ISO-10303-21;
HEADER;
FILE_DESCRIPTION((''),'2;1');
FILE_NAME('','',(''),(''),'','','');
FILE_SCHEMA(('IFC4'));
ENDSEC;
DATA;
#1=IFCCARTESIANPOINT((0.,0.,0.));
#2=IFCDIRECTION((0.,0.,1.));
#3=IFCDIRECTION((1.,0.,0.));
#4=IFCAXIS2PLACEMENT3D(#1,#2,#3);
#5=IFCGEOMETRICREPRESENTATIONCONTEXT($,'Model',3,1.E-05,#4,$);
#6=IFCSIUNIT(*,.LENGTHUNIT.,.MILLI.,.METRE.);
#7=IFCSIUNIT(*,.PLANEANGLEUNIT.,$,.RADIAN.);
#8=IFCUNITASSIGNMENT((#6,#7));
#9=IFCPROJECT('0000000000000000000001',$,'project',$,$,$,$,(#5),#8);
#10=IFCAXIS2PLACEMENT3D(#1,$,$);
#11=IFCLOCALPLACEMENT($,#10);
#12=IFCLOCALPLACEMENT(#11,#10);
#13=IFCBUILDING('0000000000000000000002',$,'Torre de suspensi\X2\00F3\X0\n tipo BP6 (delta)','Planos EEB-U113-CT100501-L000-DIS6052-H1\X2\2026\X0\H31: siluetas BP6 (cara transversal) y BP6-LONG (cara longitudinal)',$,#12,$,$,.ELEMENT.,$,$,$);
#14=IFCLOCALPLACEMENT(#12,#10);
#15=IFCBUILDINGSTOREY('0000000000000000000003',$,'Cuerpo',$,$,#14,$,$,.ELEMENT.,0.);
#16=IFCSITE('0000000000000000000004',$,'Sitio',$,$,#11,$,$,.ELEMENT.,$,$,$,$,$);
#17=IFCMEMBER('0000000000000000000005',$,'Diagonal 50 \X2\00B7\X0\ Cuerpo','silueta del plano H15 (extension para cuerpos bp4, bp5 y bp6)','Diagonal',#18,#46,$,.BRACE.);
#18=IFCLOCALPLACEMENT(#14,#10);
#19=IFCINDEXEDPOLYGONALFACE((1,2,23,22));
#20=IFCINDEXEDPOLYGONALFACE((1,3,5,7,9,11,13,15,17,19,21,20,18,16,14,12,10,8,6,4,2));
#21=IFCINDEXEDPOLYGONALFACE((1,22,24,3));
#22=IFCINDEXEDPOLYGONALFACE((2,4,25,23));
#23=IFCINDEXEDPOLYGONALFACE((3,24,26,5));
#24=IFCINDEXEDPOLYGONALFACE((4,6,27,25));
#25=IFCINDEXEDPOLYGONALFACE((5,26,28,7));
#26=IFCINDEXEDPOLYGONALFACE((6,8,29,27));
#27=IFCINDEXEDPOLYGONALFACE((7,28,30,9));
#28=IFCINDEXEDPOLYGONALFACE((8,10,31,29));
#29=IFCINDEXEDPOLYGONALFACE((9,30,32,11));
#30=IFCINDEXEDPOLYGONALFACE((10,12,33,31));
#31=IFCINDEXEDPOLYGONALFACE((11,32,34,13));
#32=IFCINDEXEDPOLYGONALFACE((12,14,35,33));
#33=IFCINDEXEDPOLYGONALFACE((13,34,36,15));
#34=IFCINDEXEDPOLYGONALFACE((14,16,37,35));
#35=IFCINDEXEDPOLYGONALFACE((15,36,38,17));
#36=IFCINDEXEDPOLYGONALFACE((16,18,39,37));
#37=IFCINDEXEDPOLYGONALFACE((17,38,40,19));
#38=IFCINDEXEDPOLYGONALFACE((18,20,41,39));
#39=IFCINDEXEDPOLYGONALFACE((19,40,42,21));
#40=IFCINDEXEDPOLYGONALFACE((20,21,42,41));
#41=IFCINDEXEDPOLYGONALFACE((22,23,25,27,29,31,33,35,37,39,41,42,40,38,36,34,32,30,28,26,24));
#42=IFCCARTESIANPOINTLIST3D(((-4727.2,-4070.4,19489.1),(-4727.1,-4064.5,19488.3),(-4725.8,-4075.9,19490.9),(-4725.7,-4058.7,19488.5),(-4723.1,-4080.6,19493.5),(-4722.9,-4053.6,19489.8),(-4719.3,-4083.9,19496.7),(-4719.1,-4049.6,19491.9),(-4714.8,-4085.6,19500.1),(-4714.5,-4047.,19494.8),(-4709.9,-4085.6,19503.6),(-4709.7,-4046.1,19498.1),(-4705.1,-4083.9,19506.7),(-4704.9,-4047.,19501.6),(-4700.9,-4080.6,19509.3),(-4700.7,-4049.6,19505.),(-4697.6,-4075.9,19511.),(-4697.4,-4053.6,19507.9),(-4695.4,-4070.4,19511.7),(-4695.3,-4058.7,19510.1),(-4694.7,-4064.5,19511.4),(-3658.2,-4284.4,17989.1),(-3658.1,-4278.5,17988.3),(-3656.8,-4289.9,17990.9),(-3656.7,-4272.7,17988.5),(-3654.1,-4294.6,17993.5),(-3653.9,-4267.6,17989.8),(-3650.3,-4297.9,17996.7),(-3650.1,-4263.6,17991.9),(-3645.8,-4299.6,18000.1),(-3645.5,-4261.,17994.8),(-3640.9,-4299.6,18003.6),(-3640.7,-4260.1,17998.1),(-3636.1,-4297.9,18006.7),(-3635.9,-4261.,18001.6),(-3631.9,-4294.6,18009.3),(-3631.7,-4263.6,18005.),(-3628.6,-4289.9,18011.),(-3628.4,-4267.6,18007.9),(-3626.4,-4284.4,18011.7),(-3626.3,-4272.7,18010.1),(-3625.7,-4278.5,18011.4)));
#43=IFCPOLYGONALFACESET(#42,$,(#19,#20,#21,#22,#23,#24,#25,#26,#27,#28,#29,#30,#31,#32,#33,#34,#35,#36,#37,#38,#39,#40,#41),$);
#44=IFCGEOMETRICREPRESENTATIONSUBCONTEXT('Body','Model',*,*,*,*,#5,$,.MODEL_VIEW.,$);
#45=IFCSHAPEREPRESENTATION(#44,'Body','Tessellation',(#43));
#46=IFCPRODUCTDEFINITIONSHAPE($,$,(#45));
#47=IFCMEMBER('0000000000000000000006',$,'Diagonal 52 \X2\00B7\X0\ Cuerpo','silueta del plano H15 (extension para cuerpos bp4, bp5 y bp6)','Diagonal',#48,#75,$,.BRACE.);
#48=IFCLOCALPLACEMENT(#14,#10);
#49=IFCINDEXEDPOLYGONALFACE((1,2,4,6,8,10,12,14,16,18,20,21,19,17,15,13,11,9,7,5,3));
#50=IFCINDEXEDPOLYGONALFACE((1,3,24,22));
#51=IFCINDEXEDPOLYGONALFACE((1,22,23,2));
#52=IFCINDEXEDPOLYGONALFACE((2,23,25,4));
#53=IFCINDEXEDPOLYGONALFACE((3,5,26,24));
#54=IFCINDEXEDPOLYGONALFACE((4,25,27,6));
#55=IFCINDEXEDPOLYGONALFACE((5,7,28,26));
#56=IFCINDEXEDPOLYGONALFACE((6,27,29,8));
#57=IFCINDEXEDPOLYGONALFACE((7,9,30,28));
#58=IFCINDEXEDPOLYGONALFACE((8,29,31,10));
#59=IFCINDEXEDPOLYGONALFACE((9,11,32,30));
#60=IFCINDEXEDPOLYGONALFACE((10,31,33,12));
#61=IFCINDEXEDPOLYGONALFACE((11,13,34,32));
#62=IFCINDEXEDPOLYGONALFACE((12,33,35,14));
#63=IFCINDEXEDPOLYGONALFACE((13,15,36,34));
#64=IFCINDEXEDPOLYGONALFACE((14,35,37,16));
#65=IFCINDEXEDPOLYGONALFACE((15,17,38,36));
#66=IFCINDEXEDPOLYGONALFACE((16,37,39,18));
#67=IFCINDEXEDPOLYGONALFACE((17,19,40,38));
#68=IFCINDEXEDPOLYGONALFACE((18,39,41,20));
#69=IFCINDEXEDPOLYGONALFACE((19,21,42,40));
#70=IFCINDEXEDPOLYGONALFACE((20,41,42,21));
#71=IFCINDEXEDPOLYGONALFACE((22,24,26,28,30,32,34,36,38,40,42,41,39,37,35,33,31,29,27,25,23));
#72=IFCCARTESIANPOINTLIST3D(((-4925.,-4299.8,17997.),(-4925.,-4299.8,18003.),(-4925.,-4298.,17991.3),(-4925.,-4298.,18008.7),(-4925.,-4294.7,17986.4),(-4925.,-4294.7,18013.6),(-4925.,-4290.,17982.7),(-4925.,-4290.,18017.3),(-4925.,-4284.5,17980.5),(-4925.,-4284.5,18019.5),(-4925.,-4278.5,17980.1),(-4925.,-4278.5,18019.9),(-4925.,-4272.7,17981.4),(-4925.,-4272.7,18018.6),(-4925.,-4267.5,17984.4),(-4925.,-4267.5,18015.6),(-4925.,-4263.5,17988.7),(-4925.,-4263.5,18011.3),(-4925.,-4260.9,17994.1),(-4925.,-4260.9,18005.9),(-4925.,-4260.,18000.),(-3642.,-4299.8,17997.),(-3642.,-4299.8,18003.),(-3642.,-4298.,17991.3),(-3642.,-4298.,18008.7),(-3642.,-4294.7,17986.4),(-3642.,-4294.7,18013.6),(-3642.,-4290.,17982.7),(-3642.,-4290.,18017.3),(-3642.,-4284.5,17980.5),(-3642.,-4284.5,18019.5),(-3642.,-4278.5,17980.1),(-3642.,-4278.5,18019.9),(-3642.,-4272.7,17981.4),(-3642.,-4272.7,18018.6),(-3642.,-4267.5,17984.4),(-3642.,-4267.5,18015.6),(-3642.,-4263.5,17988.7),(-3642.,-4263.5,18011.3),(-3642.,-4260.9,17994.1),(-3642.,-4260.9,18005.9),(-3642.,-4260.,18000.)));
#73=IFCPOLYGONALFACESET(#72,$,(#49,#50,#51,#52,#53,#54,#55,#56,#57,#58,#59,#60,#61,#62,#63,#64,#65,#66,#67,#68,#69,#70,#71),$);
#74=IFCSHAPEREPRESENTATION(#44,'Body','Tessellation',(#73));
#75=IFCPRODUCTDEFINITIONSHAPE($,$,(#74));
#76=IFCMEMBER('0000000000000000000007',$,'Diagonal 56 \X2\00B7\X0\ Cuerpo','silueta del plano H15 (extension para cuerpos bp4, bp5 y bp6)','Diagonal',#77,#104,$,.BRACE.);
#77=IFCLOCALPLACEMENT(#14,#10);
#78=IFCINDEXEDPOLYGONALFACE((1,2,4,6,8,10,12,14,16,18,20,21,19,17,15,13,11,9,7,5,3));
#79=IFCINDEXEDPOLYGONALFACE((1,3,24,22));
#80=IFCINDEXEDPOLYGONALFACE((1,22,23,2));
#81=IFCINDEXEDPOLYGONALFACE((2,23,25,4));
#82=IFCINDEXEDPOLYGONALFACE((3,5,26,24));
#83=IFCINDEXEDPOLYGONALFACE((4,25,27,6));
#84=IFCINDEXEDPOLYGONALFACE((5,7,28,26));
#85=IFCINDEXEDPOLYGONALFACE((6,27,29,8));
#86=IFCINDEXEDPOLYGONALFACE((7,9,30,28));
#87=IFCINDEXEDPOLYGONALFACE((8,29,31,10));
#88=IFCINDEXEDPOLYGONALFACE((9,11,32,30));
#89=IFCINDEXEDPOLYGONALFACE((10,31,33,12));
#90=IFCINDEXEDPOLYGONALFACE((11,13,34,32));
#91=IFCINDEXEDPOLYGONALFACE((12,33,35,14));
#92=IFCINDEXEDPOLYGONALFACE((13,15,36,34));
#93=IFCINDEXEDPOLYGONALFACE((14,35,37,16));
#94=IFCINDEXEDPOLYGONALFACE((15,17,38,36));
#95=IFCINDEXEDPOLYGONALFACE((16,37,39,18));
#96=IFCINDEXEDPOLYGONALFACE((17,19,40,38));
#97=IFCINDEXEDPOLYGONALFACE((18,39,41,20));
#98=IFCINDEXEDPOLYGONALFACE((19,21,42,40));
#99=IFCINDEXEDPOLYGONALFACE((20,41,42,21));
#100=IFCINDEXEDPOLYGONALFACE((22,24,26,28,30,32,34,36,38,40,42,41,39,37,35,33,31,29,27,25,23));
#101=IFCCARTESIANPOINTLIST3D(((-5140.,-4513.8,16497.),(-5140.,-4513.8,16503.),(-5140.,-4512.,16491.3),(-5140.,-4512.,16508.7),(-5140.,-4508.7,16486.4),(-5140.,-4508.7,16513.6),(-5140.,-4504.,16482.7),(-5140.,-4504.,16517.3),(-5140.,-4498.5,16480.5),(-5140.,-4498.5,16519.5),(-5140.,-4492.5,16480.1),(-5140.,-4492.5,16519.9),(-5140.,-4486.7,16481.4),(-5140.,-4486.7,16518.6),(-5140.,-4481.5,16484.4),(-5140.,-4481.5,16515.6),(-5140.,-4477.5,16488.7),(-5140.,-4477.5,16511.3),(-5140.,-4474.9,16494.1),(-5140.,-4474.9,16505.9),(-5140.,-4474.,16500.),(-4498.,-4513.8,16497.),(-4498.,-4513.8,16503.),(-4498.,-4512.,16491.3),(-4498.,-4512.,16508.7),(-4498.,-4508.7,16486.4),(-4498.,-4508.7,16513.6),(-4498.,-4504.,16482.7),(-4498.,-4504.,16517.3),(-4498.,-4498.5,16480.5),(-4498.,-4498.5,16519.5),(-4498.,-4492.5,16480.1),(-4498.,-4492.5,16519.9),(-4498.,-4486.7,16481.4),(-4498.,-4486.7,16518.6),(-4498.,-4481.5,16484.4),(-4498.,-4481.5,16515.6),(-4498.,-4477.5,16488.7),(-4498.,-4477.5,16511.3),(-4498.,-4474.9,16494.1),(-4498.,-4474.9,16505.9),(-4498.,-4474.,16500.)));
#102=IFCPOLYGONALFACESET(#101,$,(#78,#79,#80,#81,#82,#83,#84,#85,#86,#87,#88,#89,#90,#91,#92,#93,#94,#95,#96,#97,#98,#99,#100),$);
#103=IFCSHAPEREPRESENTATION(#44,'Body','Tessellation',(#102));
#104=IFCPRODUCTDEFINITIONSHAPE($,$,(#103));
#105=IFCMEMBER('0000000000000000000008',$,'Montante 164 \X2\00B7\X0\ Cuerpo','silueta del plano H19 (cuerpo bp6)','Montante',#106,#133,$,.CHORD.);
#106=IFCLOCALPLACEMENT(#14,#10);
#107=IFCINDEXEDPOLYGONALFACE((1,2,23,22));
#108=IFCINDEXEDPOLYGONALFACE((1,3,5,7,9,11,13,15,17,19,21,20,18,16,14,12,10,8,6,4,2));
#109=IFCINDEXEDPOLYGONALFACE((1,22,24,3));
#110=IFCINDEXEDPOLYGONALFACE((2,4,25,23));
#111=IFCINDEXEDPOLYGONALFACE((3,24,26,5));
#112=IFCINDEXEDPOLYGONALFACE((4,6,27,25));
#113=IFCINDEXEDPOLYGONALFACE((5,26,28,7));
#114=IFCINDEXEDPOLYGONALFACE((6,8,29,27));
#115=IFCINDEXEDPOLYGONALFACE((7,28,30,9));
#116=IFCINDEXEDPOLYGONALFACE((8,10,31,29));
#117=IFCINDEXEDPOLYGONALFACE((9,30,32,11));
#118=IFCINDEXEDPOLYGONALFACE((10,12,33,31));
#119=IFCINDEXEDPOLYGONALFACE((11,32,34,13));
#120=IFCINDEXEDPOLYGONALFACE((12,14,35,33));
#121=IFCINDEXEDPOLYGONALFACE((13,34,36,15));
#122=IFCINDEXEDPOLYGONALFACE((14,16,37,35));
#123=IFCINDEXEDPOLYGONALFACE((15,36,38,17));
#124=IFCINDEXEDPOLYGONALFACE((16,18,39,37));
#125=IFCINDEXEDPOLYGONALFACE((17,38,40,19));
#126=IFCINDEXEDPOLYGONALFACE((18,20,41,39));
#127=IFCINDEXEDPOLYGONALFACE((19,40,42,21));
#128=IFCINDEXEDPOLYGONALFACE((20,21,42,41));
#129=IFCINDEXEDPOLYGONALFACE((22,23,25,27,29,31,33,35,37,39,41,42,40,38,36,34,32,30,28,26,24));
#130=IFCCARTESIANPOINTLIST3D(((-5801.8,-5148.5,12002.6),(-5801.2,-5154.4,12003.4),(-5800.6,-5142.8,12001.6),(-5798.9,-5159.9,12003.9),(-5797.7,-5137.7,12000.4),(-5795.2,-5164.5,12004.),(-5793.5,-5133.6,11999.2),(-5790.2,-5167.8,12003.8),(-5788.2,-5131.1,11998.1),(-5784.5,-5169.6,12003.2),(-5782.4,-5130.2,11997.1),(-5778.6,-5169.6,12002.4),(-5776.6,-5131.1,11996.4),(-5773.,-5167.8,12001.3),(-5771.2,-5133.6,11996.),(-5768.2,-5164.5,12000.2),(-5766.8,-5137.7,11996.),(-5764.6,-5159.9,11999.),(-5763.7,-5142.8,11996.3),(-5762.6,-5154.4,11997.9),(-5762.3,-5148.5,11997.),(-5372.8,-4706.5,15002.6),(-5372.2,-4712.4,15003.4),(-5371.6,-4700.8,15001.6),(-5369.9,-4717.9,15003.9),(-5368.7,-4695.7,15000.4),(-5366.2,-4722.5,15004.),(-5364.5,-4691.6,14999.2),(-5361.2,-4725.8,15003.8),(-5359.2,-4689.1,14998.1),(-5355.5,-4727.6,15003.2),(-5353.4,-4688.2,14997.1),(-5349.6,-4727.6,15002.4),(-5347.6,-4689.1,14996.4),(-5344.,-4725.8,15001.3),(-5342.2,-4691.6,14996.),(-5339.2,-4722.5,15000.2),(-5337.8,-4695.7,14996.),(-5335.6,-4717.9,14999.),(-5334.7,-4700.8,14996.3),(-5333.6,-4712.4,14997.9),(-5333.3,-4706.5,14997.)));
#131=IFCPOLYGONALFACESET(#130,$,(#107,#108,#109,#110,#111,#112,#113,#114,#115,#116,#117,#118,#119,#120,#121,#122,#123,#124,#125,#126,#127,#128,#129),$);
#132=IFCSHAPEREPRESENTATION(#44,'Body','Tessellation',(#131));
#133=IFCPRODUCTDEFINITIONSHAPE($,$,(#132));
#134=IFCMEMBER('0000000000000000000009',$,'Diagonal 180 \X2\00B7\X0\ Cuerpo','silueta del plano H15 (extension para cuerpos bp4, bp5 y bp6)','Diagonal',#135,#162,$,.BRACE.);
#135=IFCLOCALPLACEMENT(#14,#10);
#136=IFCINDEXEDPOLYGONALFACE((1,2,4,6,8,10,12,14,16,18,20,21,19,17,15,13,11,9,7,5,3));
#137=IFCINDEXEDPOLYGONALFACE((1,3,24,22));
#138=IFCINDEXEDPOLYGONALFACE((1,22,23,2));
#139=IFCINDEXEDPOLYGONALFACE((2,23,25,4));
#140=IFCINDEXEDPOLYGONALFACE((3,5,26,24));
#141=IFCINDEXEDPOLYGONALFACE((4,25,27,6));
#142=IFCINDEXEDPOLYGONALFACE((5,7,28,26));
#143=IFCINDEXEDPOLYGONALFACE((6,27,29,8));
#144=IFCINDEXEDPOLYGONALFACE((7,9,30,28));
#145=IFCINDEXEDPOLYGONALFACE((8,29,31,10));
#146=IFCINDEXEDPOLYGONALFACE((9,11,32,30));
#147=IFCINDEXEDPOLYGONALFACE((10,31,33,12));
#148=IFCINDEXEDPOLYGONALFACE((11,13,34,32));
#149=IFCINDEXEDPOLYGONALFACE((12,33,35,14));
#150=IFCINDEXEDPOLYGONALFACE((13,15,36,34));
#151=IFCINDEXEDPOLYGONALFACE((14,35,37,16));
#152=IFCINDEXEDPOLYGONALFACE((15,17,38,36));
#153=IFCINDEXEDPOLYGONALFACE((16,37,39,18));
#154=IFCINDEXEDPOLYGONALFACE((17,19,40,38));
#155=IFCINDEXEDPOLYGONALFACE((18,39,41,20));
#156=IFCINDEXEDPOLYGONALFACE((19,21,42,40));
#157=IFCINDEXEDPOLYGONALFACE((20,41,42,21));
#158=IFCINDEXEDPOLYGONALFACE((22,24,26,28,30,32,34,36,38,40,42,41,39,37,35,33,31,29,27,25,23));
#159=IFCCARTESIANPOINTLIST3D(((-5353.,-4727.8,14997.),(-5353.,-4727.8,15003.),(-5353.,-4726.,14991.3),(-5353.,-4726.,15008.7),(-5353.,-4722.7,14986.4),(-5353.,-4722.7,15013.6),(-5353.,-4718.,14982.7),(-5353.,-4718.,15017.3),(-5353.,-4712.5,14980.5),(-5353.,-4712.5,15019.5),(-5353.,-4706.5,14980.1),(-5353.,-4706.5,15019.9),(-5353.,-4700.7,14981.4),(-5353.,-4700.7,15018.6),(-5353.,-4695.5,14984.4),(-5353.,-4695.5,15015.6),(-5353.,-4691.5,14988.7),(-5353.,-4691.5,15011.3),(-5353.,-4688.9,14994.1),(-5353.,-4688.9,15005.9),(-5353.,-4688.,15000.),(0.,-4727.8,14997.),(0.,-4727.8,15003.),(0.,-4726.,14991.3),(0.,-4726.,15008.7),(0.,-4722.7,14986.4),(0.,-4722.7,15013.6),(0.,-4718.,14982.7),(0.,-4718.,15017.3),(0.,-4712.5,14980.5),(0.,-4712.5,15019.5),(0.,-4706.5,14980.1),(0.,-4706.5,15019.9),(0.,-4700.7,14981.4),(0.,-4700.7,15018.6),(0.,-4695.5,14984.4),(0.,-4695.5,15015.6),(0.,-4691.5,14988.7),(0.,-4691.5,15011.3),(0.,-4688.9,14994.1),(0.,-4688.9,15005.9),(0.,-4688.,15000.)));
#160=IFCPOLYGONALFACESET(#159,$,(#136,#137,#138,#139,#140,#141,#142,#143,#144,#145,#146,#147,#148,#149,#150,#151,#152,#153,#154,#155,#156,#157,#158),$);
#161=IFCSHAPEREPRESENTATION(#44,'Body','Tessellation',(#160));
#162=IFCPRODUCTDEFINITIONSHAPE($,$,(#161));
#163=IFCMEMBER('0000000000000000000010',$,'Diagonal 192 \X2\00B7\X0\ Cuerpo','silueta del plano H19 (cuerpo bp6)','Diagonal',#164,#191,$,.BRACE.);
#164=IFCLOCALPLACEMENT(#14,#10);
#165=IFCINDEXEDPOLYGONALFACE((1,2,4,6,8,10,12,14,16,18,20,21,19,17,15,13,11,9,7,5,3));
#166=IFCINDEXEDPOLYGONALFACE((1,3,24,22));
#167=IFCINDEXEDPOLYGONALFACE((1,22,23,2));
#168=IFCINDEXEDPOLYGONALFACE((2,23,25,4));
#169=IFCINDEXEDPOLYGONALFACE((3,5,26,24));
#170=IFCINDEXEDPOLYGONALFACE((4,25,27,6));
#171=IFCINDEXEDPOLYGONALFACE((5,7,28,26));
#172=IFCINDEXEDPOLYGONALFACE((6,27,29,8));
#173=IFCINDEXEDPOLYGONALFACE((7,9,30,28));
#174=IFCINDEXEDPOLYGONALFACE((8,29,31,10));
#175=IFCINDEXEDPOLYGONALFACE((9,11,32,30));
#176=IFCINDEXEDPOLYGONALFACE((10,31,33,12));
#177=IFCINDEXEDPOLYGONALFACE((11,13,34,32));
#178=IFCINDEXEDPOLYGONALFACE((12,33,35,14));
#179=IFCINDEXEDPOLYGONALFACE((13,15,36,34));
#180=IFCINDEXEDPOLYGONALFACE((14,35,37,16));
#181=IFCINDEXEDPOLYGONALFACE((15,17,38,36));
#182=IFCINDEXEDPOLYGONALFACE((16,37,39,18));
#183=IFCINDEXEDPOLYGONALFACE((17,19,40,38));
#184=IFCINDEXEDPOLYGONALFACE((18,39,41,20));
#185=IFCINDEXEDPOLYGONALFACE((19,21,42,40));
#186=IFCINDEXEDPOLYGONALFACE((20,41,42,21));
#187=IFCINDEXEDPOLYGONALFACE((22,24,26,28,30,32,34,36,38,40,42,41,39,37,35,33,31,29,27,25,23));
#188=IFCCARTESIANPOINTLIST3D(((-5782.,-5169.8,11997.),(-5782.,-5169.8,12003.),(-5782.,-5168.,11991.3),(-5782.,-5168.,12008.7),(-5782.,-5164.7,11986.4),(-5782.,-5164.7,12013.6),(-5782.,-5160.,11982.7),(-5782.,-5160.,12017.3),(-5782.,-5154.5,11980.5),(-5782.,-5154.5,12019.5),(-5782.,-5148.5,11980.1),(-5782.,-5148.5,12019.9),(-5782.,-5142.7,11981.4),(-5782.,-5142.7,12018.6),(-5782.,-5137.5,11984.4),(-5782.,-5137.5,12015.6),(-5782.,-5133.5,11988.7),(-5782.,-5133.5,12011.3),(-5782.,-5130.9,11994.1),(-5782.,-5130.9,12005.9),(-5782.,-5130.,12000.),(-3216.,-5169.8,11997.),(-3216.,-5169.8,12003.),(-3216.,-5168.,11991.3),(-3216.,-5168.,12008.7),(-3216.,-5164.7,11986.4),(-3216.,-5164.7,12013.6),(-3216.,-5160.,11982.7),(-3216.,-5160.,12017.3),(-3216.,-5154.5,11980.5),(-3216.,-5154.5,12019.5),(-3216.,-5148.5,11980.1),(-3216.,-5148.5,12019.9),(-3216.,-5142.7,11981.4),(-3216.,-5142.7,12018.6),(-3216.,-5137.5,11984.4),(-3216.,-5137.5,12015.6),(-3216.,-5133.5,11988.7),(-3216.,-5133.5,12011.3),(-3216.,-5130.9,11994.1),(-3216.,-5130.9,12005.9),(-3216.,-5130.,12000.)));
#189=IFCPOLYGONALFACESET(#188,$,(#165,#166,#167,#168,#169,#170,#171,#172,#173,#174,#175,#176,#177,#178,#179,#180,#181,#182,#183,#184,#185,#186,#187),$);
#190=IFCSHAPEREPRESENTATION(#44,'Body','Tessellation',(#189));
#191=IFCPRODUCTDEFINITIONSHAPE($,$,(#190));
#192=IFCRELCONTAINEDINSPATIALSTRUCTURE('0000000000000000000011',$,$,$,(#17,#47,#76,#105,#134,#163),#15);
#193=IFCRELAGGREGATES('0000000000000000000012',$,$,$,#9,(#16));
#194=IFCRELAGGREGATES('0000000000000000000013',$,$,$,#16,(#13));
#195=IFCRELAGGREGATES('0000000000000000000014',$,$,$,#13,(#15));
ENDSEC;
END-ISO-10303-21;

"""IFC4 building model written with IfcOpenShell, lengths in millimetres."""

from ifc_helpers import new_model, si_unit, frame, origin, origin_with_axes, place, context, subcontext, project, spatial, circle, extrude, element, save


model = new_model("IFC4")

# Units and contexts
model_context = context("Model", 3, precision=1e-05, world=origin_with_axes())
body_context = subcontext(model_context, "Body", "Model", "MODEL_VIEW")
ifc_project = project(units=[si_unit("LENGTHUNIT", "METRE", prefix="MILLI"), si_unit("PLANEANGLEUNIT", "RADIAN")], contexts=[model_context])

# Site, building, storey
site_placement = place(None, origin())
site = spatial("IfcSite", under=ifc_project, at=site_placement, Name="Sitio", CompositionType="ELEMENT")
building_placement = place(site_placement, origin())
building = spatial("IfcBuilding", under=site, at=building_placement, Name="Torre de suspensión tipo BP6 (delta)", Description="Planos EEB-U113-CT100501-L000-DIS6052-H1…H31: siluetas BP6 (cara transversal) y BP6-LONG (cara longitudinal)", CompositionType="ELEMENT")
storey_placement = place(building_placement, origin())
storey = spatial("IfcBuildingStorey", under=building, at=storey_placement, Name="Cuerpo", CompositionType="ELEMENT", Elevation=0.0)

# Members
member_1_placement = place(storey_placement, frame((-3642.0, -4280.0, 18000.0), z_axis=(-0.576487, 0.115405, 0.808915), x_axis=(0.066977, 0.993318, -0.093981)))
element("IfcMember", 1, at=member_1_placement, inside=storey, Name="Diagonal 50 · Cuerpo", Description="silueta del plano H15 (extension para cuerpos bp4, bp5 y bp6)", ObjectType="Diagonal", PredefinedType="BRACE", context=body_context, shape_type="SweptSolid", body=[
    extrude(circle(Radius=20.0), None, (0.0, 0.0, 1.0), 1854.3),
])
member_2_placement = place(storey_placement, frame((-3642.0, -4280.0, 18000.0), z_axis=(-1.0, 0.0, 0.0), x_axis=(0.0, 1.0, 0.0)))
element("IfcMember", 2, at=member_2_placement, inside=storey, Name="Diagonal 52 · Cuerpo", Description="silueta del plano H15 (extension para cuerpos bp4, bp5 y bp6)", ObjectType="Diagonal", PredefinedType="BRACE", context=body_context, shape_type="SweptSolid", body=[
    extrude(circle(Radius=20.0), None, (0.0, 0.0, 1.0), 1283.0),
])
member_3_placement = place(storey_placement, frame((-4498.0, -4494.0, 16500.0), z_axis=(-1.0, 0.0, 0.0), x_axis=(0.0, 1.0, 0.0)))
element("IfcMember", 3, at=member_3_placement, inside=storey, Name="Diagonal 56 · Cuerpo", Description="silueta del plano H15 (extension para cuerpos bp4, bp5 y bp6)", ObjectType="Diagonal", PredefinedType="BRACE", context=body_context, shape_type="SweptSolid", body=[
    extrude(circle(Radius=20.0), None, (0.0, 0.0, 1.0), 642.0),
])
member_4_placement = place(storey_placement, frame((-5353.0, -4708.0, 15000.0), z_axis=(-0.140078, -0.144323, -0.979566), x_axis=(-0.02043, 0.989531, -0.142869)))
element("IfcMember", 4, at=member_4_placement, inside=storey, Name="Montante 164 · Cuerpo", Description="silueta del plano H19 (cuerpo bp6)", ObjectType="Montante", PredefinedType="CHORD", context=body_context, shape_type="SweptSolid", body=[
    extrude(circle(Radius=20.0), None, (0.0, 0.0, 1.0), 3062.6),
])
member_5_placement = place(storey_placement, frame((-5353.0, -4708.0, 15000.0), z_axis=(1.0, 0.0, 0.0), x_axis=(0.0, 1.0, 0.0)))
element("IfcMember", 5, at=member_5_placement, inside=storey, Name="Diagonal 180 · Cuerpo", Description="silueta del plano H15 (extension para cuerpos bp4, bp5 y bp6)", ObjectType="Diagonal", PredefinedType="BRACE", context=body_context, shape_type="SweptSolid", body=[
    extrude(circle(Radius=20.0), None, (0.0, 0.0, 1.0), 5353.0),
])
member_6_placement = place(storey_placement, frame((-5782.0, -5150.0, 12000.0), z_axis=(1.0, 0.0, 0.0), x_axis=(0.0, 1.0, 0.0)))
element("IfcMember", 6, at=member_6_placement, inside=storey, Name="Diagonal 192 · Cuerpo", Description="silueta del plano H19 (cuerpo bp6)", ObjectType="Diagonal", PredefinedType="BRACE", context=body_context, shape_type="SweptSolid", body=[
    extrude(circle(Radius=20.0), None, (0.0, 0.0, 1.0), 2566.0),
])

save(model, "model.ifc")
